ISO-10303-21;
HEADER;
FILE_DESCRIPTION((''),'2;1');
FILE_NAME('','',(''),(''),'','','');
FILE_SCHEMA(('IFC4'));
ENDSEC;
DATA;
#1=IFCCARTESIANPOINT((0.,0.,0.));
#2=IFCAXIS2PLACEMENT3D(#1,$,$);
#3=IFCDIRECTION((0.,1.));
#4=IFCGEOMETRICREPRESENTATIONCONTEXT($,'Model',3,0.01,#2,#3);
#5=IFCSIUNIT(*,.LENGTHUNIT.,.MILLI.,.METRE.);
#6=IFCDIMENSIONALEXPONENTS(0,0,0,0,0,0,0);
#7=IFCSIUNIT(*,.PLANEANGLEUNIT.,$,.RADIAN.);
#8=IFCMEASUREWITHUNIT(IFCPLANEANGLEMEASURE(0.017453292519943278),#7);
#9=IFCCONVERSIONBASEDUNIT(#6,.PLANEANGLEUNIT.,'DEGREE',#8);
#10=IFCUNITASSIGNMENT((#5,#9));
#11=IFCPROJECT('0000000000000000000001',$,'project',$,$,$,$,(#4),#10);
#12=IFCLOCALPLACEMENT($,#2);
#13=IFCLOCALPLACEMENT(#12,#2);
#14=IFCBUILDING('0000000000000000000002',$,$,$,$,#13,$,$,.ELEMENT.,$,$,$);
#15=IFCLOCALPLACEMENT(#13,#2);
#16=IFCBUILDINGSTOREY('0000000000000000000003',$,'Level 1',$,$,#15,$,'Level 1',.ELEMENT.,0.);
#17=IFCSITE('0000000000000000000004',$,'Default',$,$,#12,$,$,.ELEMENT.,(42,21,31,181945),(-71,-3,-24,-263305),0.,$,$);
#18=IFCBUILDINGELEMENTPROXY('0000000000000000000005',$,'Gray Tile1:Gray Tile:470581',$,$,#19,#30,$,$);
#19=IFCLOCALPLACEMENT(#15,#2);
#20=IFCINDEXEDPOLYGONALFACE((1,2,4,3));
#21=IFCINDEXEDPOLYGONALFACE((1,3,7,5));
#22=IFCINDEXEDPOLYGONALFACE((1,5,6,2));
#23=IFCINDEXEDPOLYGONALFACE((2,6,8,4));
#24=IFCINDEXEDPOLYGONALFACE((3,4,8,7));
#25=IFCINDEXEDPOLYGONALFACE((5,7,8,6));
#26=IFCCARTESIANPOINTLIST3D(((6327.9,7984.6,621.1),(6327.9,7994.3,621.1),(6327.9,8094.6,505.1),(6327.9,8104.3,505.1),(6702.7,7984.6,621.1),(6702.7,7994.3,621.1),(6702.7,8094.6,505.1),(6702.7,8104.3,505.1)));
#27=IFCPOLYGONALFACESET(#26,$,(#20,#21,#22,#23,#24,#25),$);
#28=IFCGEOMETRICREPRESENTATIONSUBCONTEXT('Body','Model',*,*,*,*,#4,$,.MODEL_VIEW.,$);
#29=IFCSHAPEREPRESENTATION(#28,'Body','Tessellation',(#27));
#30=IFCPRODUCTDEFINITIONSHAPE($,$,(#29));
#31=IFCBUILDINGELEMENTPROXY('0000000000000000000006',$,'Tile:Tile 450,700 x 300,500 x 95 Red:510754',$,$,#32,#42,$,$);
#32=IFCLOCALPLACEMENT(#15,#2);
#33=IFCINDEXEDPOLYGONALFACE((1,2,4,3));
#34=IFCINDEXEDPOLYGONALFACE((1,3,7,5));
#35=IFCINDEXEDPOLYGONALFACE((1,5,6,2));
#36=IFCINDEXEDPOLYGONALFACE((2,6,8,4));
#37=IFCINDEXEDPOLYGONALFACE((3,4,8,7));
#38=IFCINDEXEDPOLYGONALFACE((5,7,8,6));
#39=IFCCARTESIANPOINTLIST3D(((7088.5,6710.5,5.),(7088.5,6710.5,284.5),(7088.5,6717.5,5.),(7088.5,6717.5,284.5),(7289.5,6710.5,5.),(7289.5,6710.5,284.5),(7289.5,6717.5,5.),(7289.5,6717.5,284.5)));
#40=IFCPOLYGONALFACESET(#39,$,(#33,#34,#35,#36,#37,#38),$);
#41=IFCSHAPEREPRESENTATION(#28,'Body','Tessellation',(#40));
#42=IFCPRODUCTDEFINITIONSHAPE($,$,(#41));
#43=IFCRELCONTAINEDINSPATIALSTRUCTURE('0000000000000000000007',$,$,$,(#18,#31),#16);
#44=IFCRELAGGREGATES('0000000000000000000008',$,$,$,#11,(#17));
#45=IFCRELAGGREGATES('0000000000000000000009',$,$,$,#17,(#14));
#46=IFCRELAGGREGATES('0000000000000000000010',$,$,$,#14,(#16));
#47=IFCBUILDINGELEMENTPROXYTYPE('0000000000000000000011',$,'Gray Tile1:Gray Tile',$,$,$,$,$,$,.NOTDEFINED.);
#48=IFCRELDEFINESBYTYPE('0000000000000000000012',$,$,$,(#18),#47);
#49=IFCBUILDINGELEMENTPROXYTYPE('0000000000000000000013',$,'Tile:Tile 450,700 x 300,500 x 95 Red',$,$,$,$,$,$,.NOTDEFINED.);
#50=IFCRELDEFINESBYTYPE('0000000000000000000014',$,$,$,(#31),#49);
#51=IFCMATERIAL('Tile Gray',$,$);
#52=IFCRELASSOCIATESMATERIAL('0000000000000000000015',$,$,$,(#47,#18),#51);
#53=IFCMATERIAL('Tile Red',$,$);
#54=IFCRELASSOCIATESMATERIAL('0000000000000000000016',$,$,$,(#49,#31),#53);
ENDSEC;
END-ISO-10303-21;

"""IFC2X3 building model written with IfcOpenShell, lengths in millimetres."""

from ifc_helpers import new_model, entity, si_unit, converted_unit, direction, frame, frame_2d, origin, place, context, subcontext, project, spatial, polyline, rectangle, outline, extrude, source, transform, mapped, material, type_object, type_shapes, element, save


model = new_model("IFC2X3")

# Units and contexts
model_context = context("Model", 3, precision=0.01, world=origin(), true_north=direction((0.0, 1.0)))
body_context = subcontext(model_context, "Body", "Model", "MODEL_VIEW")
ifc_project = project(units=[si_unit("LENGTHUNIT", "METRE", prefix="MILLI"), converted_unit("PLANEANGLEUNIT", "DEGREE", entity("IfcPlaneAngleMeasure", 0.017453292519943278), si_unit("PLANEANGLEUNIT", "RADIAN"), dimensions=[0, 0, 0, 0, 0, 0, 0])], contexts=[model_context])

# Site, building, storey
site_placement = place(None, origin())
site = spatial("IfcSite", under=ifc_project, at=site_placement, Name="Default", CompositionType="ELEMENT", RefLatitude=(42, 21, 31, 181945), RefLongitude=(-71, -3, -24, -263305), RefElevation=0.0)
building_placement = place(site_placement, origin())
building = spatial("IfcBuilding", under=site, at=building_placement, CompositionType="ELEMENT")
storey_placement = place(building_placement, origin())
storey = spatial("IfcBuildingStorey", under=building, at=storey_placement, Name="Level 1", LongName="Level 1", CompositionType="ELEMENT", Elevation=0.0)

# Building element proxies
ifc_material_1 = material(Name="Tile Gray")
building_element_proxy_type_1 = type_object("IfcBuildingElementProxyType", Name="Gray Tile1:Gray Tile", PredefinedType="NOTDEFINED", material=ifc_material_1)
shared_shape_1 = source(origin(), body_context, "Body", "SweptSolid", [
    extrude(outline(polyline([(-83.3, -3.5), (76.6, -3.5), (83.3, 3.5), (-76.6, 3.5), (-83.3, -3.5)])), frame((6327.9, 8039.2, 555.7), z_axis=(1.0, 0.0, 0.0), x_axis=(0.0, -0.688092, 0.725624)), (0.0, 0.0, 1.0), 374.8),
])
type_shapes(building_element_proxy_type_1, [shared_shape_1])
proxy_1_placement = place(storey_placement, frame((0.0, 5.2, 7.5)))
element("IfcBuildingElementProxy", 1, at=proxy_1_placement, inside=storey, type_object=building_element_proxy_type_1, material=ifc_material_1, Name="Gray Tile1:Gray Tile:470581", context=body_context, shape_type="MappedRepresentation", body=[
    mapped(shared_shape_1, transform((0.0, 0.0, 0.0), scale=1.0)),
])
ifc_material_2 = material(Name="Tile Red")
building_element_proxy_type_2 = type_object("IfcBuildingElementProxyType", Name="Tile:Tile 450,700 x 300,500 x 95 Red", PredefinedType="NOTDEFINED", material=ifc_material_2)
shared_shape_2 = source(origin(), body_context, "Body", "SweptSolid", [
    extrude(rectangle(XDim=201.0, YDim=279.5, at=frame_2d((0.0, 0.0), x_axis=(1.0, 0.0))), frame((-100.5, -139.7, 0.0), z_axis=(0.0, 0.0, 1.0), x_axis=(-1.0, 0.0, 0.0)), (0.0, 0.0, 1.0), 7.0),
])
type_shapes(building_element_proxy_type_2, [shared_shape_2])
proxy_2_placement = place(storey_placement, frame((7088.5, 6717.5, 5.0), z_axis=(0.0, -1.0, 0.0), x_axis=(-1.0, 0.0, 0.0)))
element("IfcBuildingElementProxy", 2, at=proxy_2_placement, inside=storey, type_object=building_element_proxy_type_2, material=ifc_material_2, Name="Tile:Tile 450,700 x 300,500 x 95 Red:510754", context=body_context, shape_type="MappedRepresentation", body=[
    mapped(shared_shape_2, transform((0.0, 0.0, 0.0), scale=1.0)),
])

save(model, "model.ifc")
